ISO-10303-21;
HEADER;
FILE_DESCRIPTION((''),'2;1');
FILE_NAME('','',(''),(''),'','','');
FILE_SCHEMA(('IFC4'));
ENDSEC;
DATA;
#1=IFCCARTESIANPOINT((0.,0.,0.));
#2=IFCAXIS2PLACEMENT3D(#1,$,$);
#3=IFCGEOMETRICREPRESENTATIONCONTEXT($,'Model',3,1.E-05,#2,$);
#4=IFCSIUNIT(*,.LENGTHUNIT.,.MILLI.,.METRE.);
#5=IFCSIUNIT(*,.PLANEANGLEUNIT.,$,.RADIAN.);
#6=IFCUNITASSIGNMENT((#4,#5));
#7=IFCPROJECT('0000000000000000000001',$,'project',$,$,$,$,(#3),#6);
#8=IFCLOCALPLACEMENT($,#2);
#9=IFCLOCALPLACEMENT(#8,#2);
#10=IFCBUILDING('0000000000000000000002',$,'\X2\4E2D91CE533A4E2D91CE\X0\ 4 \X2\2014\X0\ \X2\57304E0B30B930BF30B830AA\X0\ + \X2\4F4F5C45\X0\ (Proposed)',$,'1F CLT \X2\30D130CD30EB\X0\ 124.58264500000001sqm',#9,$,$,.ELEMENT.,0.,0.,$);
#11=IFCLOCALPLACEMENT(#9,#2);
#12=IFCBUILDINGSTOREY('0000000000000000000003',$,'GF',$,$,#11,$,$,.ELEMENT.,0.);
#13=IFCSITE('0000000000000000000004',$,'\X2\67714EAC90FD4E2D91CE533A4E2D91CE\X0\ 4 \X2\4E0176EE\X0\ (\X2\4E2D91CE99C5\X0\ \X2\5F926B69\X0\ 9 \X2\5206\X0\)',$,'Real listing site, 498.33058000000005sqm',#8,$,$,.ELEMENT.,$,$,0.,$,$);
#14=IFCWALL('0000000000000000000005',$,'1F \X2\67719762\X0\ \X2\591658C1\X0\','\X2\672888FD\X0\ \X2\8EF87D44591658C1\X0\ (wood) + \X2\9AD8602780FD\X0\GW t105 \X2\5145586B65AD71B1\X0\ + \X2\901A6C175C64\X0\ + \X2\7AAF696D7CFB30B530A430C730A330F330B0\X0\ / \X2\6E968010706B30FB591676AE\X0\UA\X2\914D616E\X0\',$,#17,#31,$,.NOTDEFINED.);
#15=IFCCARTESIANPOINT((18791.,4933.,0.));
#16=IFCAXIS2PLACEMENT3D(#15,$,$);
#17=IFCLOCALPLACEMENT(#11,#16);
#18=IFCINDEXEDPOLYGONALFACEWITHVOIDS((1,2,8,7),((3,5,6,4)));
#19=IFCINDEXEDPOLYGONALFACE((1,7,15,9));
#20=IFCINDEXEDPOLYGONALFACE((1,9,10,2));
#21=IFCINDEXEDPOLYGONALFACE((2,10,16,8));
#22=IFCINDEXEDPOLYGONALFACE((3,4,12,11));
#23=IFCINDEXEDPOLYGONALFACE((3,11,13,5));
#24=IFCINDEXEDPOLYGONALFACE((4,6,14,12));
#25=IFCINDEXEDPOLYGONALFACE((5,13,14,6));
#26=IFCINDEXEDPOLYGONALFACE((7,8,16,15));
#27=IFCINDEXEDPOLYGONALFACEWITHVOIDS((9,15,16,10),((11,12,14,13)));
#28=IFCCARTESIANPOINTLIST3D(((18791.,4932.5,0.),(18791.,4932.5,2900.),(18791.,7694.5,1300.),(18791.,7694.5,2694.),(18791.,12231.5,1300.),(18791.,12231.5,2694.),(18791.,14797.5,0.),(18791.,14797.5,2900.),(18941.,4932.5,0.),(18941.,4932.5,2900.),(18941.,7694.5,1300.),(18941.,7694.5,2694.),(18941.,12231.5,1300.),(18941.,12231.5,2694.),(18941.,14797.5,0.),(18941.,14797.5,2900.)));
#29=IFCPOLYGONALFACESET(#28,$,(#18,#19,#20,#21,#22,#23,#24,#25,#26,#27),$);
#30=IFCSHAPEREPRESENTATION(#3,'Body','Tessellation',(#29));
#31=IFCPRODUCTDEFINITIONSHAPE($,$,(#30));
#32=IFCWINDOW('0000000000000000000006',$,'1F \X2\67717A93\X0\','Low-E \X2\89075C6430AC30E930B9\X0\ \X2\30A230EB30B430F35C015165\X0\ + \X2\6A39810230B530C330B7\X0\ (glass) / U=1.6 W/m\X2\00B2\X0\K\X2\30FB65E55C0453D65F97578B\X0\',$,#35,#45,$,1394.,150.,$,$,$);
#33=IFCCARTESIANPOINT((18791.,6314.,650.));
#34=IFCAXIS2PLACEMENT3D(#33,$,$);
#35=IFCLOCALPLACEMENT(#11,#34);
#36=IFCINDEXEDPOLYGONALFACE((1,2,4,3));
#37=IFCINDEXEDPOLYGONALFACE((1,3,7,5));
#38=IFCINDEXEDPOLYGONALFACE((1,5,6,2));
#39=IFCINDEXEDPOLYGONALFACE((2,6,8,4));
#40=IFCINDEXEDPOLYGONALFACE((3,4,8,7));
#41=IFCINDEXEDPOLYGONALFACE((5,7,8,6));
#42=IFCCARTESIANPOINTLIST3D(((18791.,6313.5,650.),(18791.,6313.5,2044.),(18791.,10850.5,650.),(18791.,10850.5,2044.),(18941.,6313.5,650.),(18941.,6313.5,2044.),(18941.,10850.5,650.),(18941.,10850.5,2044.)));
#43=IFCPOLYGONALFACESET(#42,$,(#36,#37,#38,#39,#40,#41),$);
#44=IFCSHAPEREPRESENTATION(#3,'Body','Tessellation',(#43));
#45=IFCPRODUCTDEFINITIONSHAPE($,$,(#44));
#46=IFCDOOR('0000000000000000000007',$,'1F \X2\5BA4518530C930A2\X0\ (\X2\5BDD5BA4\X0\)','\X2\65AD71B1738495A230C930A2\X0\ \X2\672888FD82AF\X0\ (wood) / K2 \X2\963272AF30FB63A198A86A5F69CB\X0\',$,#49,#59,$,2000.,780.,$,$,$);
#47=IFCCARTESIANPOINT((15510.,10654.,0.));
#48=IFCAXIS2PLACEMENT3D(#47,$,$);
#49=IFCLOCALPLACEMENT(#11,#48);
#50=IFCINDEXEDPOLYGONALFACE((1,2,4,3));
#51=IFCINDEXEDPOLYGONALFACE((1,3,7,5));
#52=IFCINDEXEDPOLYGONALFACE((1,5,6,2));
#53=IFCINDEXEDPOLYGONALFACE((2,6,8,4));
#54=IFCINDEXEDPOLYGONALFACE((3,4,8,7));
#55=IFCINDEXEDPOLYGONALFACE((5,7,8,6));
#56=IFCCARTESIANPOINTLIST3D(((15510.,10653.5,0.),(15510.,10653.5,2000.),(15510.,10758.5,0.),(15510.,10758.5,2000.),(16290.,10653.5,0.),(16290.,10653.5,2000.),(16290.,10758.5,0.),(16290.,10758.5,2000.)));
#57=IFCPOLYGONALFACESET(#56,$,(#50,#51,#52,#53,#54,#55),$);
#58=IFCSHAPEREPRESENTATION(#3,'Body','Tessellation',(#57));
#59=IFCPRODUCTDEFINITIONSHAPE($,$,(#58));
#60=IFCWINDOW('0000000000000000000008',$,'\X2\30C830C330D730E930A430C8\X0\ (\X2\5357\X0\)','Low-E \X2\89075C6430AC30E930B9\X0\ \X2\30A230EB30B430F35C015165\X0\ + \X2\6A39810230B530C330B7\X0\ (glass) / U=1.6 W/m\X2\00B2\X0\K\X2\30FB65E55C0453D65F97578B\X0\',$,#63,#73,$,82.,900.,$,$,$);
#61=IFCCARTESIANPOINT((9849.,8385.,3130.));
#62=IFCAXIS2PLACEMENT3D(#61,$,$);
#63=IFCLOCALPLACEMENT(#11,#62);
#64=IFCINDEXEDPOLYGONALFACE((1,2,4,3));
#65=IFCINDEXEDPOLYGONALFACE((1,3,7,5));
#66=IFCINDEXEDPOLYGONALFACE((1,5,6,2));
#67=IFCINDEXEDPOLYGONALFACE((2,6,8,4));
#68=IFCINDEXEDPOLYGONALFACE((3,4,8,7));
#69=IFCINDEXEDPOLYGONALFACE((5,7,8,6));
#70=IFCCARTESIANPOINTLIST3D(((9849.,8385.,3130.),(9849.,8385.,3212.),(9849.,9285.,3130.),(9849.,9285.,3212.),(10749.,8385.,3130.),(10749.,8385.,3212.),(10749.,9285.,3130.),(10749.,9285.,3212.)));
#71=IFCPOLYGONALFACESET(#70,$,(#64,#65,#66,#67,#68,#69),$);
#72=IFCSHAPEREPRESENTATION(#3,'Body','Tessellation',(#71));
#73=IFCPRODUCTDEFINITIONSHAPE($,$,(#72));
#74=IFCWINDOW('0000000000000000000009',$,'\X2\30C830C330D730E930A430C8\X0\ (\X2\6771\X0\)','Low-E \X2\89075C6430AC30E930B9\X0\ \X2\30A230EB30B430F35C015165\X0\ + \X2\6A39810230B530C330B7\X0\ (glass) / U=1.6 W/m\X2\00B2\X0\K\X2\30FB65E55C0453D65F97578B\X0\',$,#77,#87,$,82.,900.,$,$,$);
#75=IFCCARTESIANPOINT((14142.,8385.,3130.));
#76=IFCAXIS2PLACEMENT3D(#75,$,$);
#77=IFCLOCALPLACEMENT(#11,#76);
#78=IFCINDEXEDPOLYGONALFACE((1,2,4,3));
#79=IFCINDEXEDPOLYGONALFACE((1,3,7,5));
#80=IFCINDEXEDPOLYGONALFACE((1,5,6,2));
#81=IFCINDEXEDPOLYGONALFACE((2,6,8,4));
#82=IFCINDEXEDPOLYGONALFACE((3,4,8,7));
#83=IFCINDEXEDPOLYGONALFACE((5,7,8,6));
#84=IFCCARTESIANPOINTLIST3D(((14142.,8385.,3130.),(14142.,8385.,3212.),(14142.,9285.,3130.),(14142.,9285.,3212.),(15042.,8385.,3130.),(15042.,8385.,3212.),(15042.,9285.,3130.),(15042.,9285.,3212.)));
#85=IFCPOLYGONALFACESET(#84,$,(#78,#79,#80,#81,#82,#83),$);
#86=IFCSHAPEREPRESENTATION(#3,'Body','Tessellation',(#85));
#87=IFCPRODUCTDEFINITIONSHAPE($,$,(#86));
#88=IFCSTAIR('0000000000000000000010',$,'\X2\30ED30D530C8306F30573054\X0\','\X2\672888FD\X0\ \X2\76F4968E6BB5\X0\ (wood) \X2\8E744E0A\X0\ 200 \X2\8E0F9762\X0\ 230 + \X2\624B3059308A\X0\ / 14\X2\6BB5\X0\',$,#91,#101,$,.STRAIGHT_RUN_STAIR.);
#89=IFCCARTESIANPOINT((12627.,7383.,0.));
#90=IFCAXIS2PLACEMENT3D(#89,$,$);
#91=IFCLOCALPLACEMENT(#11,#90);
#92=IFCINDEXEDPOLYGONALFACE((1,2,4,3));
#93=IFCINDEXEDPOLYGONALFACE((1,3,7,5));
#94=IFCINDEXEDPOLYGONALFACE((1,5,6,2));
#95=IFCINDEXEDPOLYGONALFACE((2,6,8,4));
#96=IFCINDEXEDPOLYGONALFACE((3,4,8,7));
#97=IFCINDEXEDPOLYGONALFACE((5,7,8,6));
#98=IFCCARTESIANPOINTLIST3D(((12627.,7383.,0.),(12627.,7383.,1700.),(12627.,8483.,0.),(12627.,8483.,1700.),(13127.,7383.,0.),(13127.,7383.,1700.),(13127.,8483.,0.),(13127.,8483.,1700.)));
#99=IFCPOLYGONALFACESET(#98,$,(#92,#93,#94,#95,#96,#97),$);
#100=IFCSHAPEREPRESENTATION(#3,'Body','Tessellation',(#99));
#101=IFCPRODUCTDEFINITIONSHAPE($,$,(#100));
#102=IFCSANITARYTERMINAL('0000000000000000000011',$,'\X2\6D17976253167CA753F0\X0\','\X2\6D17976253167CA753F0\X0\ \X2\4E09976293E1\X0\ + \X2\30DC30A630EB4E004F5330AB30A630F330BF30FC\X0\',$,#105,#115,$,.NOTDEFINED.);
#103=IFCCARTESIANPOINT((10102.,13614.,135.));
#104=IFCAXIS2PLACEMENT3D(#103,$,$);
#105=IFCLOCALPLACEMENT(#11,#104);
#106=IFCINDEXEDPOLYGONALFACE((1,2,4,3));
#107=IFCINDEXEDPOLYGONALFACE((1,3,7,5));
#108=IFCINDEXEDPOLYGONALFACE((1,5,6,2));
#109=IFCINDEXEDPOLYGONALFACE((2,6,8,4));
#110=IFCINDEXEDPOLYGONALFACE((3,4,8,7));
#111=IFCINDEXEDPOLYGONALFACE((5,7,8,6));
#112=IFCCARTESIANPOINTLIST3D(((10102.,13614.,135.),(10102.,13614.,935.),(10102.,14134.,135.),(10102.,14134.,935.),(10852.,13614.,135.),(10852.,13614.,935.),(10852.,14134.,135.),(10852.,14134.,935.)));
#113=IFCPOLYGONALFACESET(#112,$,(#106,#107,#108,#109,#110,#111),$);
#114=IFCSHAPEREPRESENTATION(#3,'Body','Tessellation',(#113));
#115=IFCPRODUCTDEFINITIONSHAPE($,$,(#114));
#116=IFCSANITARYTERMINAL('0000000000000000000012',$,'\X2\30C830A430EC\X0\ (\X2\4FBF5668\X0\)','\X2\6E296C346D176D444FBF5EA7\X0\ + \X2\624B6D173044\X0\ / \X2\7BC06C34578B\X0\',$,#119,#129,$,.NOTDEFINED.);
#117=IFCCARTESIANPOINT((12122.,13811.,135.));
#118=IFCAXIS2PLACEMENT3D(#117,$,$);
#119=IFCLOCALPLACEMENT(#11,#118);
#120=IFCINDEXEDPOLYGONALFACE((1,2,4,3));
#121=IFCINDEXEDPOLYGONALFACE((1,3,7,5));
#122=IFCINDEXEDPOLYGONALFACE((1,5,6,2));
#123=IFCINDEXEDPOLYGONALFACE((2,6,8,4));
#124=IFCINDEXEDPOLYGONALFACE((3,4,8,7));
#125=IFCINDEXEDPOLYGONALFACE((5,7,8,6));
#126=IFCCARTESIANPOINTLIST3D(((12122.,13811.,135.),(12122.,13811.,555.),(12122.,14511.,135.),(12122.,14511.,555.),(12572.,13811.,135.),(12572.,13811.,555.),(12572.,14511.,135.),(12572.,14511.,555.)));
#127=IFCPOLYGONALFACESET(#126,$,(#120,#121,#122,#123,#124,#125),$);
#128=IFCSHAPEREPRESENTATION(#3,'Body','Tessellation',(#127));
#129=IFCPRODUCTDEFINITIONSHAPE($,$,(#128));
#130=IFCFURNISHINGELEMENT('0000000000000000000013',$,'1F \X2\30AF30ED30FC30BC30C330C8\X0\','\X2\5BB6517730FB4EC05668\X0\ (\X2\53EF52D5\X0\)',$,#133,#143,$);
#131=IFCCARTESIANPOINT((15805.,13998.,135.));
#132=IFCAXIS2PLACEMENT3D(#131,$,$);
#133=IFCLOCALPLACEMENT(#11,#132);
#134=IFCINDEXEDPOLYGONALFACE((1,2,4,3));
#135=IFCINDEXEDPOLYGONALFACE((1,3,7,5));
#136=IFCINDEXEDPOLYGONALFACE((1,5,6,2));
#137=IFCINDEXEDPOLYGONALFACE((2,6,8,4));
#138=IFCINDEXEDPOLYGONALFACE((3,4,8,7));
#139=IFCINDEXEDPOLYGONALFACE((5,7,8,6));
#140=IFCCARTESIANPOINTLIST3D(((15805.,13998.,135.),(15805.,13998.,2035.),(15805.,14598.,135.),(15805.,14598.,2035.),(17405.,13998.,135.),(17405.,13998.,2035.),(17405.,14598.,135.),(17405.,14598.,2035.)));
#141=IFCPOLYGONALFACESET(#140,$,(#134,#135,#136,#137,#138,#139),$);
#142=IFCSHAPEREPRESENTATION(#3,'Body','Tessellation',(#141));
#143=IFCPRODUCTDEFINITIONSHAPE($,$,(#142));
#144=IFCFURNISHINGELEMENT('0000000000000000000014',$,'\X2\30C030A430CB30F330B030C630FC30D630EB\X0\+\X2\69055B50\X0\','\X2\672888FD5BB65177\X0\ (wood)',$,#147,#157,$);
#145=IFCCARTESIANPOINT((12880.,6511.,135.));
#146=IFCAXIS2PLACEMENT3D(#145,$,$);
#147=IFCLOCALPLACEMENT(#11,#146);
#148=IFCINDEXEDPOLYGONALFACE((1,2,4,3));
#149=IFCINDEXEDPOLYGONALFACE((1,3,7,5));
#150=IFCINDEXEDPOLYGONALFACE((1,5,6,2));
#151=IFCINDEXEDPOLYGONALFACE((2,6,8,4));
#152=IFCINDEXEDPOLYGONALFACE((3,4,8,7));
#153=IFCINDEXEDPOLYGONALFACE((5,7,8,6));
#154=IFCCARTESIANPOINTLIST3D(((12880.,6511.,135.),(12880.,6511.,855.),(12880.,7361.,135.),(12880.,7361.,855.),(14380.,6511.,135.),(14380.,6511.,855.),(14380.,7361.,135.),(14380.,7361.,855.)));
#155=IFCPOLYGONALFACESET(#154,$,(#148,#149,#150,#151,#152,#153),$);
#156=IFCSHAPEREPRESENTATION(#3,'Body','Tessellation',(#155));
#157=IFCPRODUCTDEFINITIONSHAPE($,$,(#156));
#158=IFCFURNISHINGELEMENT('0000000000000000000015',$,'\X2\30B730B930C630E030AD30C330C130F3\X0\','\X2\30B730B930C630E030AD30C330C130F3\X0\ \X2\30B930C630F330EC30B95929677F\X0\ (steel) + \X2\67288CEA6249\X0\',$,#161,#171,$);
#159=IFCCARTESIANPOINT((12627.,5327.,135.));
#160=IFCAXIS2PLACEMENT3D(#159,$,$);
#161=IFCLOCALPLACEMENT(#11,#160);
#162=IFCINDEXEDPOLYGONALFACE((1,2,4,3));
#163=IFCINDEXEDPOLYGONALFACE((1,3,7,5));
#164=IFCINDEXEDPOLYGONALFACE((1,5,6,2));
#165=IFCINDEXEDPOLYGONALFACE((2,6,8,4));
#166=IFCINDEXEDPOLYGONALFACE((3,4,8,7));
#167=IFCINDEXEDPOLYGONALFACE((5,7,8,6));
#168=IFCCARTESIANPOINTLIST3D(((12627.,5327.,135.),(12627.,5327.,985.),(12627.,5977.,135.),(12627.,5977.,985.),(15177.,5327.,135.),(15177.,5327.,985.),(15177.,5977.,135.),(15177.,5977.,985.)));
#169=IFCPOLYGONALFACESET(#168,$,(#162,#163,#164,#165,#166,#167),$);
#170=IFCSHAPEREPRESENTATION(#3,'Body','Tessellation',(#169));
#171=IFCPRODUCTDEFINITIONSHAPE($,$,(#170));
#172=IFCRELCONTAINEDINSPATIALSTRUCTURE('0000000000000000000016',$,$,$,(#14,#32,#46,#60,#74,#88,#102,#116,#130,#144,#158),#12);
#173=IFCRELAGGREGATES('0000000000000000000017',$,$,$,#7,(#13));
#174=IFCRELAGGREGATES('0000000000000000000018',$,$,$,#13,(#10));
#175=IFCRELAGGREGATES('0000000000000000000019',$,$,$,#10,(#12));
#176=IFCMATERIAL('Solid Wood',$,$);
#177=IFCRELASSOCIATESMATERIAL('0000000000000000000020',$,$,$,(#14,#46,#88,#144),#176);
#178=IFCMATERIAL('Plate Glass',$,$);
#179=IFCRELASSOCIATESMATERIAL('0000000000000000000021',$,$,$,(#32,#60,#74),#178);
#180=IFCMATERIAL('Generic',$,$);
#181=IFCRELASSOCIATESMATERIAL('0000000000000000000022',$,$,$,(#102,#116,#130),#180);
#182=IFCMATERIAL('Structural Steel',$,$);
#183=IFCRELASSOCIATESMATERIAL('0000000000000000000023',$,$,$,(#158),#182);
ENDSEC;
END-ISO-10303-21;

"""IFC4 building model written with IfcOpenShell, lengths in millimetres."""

from ifc_helpers import new_model, si_unit, frame, frame_2d, origin, place, context, project, spatial, rectangle, extrude, material, element, fill, save


model = new_model("IFC4")

# Units and contexts
model_context = context("Model", 3, precision=1e-05, world=origin())
ifc_project = project(units=[si_unit("LENGTHUNIT", "METRE", prefix="MILLI"), si_unit("PLANEANGLEUNIT", "RADIAN")], contexts=[model_context])

# Site, building, storey
site_placement = place(None, origin())
site = spatial("IfcSite", under=ifc_project, at=site_placement, Name="東京都中野区中野 4 丁目 (中野駅 徒歩 9 分)", ObjectType="Real listing site, 498.33058000000005sqm", CompositionType="ELEMENT", RefElevation=0.0)
building_placement = place(site_placement, origin())
building = spatial("IfcBuilding", under=site, at=building_placement, Name="中野区中野 4 — 地下スタジオ + 住居 (Proposed)", ObjectType="1F CLT パネル 124.58264500000001sqm", CompositionType="ELEMENT", ElevationOfRefHeight=0.0, ElevationOfTerrain=0.0)
storey_placement = place(building_placement, origin())
storey = spatial("IfcBuildingStorey", under=building, at=storey_placement, Name="GF", CompositionType="ELEMENT", Elevation=0.0)

# Wall, opening, window
ifc_material_1 = material(Name="Solid Wood")
wall_1_placement = place(storey_placement, frame((18791.0, 4933.0, 0.0)))
wall_1 = element("IfcWall", 1, at=wall_1_placement, inside=storey, material=ifc_material_1, Name="1F 東面 外壁", Description="木製 軸組外壁 (wood) + 高性能GW t105 充填断熱 + 通気層 + 窯業系サイディング / 準耐火・外皮UA配慮", PredefinedType="NOTDEFINED", context=model_context, shape_type="SweptSolid", body=[
    extrude(rectangle(XDim=150.0, YDim=9865.0, at=frame_2d((75.0, 4932.0))), frame((18791.0, 4933.0, 0.0)), (0.0, 0.0, 1.0), 2900.0),
])
opening_placement = place(storey_placement, frame((18791.0, 6314.0, 650.0)))
opening = element("IfcOpeningElement", 2, at=opening_placement, cuts=wall_1, PredefinedType="NOTDEFINED", context=model_context, shape_type="SweptSolid", body=[
    extrude(rectangle(XDim=150.0, YDim=4537.0, at=frame_2d((75.0, 2268.0))), frame((18791.0, 6314.0, 650.0)), (0.0, 0.0, 1.0), 1394.0),
])
ifc_material_2 = material(Name="Plate Glass")
window_1_placement = place(storey_placement, frame((18791.0, 6314.0, 650.0)))
window_1 = element("IfcWindow", 3, at=window_1_placement, inside=storey, material=ifc_material_2, Name="1F 東窓", Description="Low-E 複層ガラス アルゴン封入 + 樹脂サッシ (glass) / U=1.6 W/m²K・日射取得型", OverallHeight=1394.0, OverallWidth=150.0, context=model_context, shape_type="SweptSolid", body=[
    extrude(rectangle(XDim=150.0, YDim=4537.0, at=frame_2d((75.0, 2268.0))), frame((18791.0, 6314.0, 650.0)), (0.0, 0.0, 1.0), 1394.0),
])
fill(opening, window_1)

# Door
door_placement = place(storey_placement, frame((15510.0, 10654.0, 0.0)))
element("IfcDoor", 4, at=door_placement, inside=storey, material=ifc_material_1, Name="1F 室内ドア (寝室)", Description="断熱玄関ドア 木製芯 (wood) / K2 防犯・採風機構", OverallHeight=2000.0, OverallWidth=780.0, context=model_context, shape_type="SweptSolid", body=[
    extrude(rectangle(XDim=780.0, YDim=105.0, at=frame_2d((390.0, 52.0))), frame((15510.0, 10654.0, 0.0)), (0.0, 0.0, 1.0), 2000.0),
])

# Windows
window_2_placement = place(storey_placement, frame((9849.0, 8385.0, 3130.0)))
element("IfcWindow", 5, at=window_2_placement, inside=storey, material=ifc_material_2, Name="トップライト (南)", Description="Low-E 複層ガラス アルゴン封入 + 樹脂サッシ (glass) / U=1.6 W/m²K・日射取得型", OverallHeight=82.0, OverallWidth=900.0, context=model_context, shape_type="SweptSolid", body=[
    extrude(rectangle(XDim=900.0, YDim=900.0, at=frame_2d((450.0, 450.0))), frame((9849.0, 8385.0, 3130.0)), (0.0, 0.0, 1.0), 82.0),
])
window_3_placement = place(storey_placement, frame((14142.0, 8385.0, 3130.0)))
element("IfcWindow", 6, at=window_3_placement, inside=storey, material=ifc_material_2, Name="トップライト (東)", Description="Low-E 複層ガラス アルゴン封入 + 樹脂サッシ (glass) / U=1.6 W/m²K・日射取得型", OverallHeight=82.0, OverallWidth=900.0, context=model_context, shape_type="SweptSolid", body=[
    extrude(rectangle(XDim=900.0, YDim=900.0, at=frame_2d((450.0, 450.0))), frame((14142.0, 8385.0, 3130.0)), (0.0, 0.0, 1.0), 82.0),
])

# Stair
stair_placement = place(storey_placement, frame((12627.0, 7383.0, 0.0)))
element("IfcStair", 7, at=stair_placement, inside=storey, material=ifc_material_1, Name="ロフトはしご", Description="木製 直階段 (wood) 蹴上 200 踏面 230 + 手すり / 14段", PredefinedType="STRAIGHT_RUN_STAIR", context=model_context, shape_type="SweptSolid", body=[
    extrude(rectangle(XDim=500.0, YDim=1100.0, at=frame_2d((250.0, 550.0))), frame((12627.0, 7383.0, 0.0)), (0.0, 0.0, 1.0), 1700.0),
])

# Sanitary terminals
ifc_material_3 = material(Name="Generic")
sanitary_terminal_1_placement = place(storey_placement, frame((10102.0, 13614.0, 135.0)))
element("IfcSanitaryTerminal", 8, at=sanitary_terminal_1_placement, inside=storey, material=ifc_material_3, Name="洗面化粧台", Description="洗面化粧台 三面鏡 + ボウル一体カウンター", PredefinedType="NOTDEFINED", context=model_context, shape_type="SweptSolid", body=[
    extrude(rectangle(XDim=750.0, YDim=520.0, at=frame_2d((375.0, 260.0))), frame((10102.0, 13614.0, 135.0)), (0.0, 0.0, 1.0), 800.0),
])
sanitary_terminal_2_placement = place(storey_placement, frame((12122.0, 13811.0, 135.0)))
element("IfcSanitaryTerminal", 9, at=sanitary_terminal_2_placement, inside=storey, material=ifc_material_3, Name="トイレ (便器)", Description="温水洗浄便座 + 手洗い / 節水型", PredefinedType="NOTDEFINED", context=model_context, shape_type="SweptSolid", body=[
    extrude(rectangle(XDim=450.0, YDim=700.0, at=frame_2d((225.0, 350.0))), frame((12122.0, 13811.0, 135.0)), (0.0, 0.0, 1.0), 420.0),
])

# Furnishing elements
furnishing_1_placement = place(storey_placement, frame((15805.0, 13998.0, 135.0)))
element("IfcFurnishingElement", 10, at=furnishing_1_placement, inside=storey, material=ifc_material_3, Name="1F クローゼット", Description="家具・什器 (可動)", context=model_context, shape_type="SweptSolid", body=[
    extrude(rectangle(XDim=1600.0, YDim=600.0, at=frame_2d((800.0, 300.0))), frame((15805.0, 13998.0, 135.0)), (0.0, 0.0, 1.0), 1900.0),
])
furnishing_2_placement = place(storey_placement, frame((12880.0, 6511.0, 135.0)))
element("IfcFurnishingElement", 11, at=furnishing_2_placement, inside=storey, material=ifc_material_1, Name="ダイニングテーブル+椅子", Description="木製家具 (wood)", context=model_context, shape_type="SweptSolid", body=[
    extrude(rectangle(XDim=1500.0, YDim=850.0, at=frame_2d((750.0, 425.0))), frame((12880.0, 6511.0, 135.0)), (0.0, 0.0, 1.0), 720.0),
])
ifc_material_4 = material(Name="Structural Steel")
furnishing_3_placement = place(storey_placement, frame((12627.0, 5327.0, 135.0)))
element("IfcFurnishingElement", 12, at=furnishing_3_placement, inside=storey, material=ifc_material_4, Name="システムキッチン", Description="システムキッチン ステンレス天板 (steel) + 木質扉", context=model_context, shape_type="SweptSolid", body=[
    extrude(rectangle(XDim=2550.0, YDim=650.0, at=frame_2d((1275.0, 325.0))), frame((12627.0, 5327.0, 135.0)), (0.0, 0.0, 1.0), 850.0),
])

save(model, "model.ifc")
